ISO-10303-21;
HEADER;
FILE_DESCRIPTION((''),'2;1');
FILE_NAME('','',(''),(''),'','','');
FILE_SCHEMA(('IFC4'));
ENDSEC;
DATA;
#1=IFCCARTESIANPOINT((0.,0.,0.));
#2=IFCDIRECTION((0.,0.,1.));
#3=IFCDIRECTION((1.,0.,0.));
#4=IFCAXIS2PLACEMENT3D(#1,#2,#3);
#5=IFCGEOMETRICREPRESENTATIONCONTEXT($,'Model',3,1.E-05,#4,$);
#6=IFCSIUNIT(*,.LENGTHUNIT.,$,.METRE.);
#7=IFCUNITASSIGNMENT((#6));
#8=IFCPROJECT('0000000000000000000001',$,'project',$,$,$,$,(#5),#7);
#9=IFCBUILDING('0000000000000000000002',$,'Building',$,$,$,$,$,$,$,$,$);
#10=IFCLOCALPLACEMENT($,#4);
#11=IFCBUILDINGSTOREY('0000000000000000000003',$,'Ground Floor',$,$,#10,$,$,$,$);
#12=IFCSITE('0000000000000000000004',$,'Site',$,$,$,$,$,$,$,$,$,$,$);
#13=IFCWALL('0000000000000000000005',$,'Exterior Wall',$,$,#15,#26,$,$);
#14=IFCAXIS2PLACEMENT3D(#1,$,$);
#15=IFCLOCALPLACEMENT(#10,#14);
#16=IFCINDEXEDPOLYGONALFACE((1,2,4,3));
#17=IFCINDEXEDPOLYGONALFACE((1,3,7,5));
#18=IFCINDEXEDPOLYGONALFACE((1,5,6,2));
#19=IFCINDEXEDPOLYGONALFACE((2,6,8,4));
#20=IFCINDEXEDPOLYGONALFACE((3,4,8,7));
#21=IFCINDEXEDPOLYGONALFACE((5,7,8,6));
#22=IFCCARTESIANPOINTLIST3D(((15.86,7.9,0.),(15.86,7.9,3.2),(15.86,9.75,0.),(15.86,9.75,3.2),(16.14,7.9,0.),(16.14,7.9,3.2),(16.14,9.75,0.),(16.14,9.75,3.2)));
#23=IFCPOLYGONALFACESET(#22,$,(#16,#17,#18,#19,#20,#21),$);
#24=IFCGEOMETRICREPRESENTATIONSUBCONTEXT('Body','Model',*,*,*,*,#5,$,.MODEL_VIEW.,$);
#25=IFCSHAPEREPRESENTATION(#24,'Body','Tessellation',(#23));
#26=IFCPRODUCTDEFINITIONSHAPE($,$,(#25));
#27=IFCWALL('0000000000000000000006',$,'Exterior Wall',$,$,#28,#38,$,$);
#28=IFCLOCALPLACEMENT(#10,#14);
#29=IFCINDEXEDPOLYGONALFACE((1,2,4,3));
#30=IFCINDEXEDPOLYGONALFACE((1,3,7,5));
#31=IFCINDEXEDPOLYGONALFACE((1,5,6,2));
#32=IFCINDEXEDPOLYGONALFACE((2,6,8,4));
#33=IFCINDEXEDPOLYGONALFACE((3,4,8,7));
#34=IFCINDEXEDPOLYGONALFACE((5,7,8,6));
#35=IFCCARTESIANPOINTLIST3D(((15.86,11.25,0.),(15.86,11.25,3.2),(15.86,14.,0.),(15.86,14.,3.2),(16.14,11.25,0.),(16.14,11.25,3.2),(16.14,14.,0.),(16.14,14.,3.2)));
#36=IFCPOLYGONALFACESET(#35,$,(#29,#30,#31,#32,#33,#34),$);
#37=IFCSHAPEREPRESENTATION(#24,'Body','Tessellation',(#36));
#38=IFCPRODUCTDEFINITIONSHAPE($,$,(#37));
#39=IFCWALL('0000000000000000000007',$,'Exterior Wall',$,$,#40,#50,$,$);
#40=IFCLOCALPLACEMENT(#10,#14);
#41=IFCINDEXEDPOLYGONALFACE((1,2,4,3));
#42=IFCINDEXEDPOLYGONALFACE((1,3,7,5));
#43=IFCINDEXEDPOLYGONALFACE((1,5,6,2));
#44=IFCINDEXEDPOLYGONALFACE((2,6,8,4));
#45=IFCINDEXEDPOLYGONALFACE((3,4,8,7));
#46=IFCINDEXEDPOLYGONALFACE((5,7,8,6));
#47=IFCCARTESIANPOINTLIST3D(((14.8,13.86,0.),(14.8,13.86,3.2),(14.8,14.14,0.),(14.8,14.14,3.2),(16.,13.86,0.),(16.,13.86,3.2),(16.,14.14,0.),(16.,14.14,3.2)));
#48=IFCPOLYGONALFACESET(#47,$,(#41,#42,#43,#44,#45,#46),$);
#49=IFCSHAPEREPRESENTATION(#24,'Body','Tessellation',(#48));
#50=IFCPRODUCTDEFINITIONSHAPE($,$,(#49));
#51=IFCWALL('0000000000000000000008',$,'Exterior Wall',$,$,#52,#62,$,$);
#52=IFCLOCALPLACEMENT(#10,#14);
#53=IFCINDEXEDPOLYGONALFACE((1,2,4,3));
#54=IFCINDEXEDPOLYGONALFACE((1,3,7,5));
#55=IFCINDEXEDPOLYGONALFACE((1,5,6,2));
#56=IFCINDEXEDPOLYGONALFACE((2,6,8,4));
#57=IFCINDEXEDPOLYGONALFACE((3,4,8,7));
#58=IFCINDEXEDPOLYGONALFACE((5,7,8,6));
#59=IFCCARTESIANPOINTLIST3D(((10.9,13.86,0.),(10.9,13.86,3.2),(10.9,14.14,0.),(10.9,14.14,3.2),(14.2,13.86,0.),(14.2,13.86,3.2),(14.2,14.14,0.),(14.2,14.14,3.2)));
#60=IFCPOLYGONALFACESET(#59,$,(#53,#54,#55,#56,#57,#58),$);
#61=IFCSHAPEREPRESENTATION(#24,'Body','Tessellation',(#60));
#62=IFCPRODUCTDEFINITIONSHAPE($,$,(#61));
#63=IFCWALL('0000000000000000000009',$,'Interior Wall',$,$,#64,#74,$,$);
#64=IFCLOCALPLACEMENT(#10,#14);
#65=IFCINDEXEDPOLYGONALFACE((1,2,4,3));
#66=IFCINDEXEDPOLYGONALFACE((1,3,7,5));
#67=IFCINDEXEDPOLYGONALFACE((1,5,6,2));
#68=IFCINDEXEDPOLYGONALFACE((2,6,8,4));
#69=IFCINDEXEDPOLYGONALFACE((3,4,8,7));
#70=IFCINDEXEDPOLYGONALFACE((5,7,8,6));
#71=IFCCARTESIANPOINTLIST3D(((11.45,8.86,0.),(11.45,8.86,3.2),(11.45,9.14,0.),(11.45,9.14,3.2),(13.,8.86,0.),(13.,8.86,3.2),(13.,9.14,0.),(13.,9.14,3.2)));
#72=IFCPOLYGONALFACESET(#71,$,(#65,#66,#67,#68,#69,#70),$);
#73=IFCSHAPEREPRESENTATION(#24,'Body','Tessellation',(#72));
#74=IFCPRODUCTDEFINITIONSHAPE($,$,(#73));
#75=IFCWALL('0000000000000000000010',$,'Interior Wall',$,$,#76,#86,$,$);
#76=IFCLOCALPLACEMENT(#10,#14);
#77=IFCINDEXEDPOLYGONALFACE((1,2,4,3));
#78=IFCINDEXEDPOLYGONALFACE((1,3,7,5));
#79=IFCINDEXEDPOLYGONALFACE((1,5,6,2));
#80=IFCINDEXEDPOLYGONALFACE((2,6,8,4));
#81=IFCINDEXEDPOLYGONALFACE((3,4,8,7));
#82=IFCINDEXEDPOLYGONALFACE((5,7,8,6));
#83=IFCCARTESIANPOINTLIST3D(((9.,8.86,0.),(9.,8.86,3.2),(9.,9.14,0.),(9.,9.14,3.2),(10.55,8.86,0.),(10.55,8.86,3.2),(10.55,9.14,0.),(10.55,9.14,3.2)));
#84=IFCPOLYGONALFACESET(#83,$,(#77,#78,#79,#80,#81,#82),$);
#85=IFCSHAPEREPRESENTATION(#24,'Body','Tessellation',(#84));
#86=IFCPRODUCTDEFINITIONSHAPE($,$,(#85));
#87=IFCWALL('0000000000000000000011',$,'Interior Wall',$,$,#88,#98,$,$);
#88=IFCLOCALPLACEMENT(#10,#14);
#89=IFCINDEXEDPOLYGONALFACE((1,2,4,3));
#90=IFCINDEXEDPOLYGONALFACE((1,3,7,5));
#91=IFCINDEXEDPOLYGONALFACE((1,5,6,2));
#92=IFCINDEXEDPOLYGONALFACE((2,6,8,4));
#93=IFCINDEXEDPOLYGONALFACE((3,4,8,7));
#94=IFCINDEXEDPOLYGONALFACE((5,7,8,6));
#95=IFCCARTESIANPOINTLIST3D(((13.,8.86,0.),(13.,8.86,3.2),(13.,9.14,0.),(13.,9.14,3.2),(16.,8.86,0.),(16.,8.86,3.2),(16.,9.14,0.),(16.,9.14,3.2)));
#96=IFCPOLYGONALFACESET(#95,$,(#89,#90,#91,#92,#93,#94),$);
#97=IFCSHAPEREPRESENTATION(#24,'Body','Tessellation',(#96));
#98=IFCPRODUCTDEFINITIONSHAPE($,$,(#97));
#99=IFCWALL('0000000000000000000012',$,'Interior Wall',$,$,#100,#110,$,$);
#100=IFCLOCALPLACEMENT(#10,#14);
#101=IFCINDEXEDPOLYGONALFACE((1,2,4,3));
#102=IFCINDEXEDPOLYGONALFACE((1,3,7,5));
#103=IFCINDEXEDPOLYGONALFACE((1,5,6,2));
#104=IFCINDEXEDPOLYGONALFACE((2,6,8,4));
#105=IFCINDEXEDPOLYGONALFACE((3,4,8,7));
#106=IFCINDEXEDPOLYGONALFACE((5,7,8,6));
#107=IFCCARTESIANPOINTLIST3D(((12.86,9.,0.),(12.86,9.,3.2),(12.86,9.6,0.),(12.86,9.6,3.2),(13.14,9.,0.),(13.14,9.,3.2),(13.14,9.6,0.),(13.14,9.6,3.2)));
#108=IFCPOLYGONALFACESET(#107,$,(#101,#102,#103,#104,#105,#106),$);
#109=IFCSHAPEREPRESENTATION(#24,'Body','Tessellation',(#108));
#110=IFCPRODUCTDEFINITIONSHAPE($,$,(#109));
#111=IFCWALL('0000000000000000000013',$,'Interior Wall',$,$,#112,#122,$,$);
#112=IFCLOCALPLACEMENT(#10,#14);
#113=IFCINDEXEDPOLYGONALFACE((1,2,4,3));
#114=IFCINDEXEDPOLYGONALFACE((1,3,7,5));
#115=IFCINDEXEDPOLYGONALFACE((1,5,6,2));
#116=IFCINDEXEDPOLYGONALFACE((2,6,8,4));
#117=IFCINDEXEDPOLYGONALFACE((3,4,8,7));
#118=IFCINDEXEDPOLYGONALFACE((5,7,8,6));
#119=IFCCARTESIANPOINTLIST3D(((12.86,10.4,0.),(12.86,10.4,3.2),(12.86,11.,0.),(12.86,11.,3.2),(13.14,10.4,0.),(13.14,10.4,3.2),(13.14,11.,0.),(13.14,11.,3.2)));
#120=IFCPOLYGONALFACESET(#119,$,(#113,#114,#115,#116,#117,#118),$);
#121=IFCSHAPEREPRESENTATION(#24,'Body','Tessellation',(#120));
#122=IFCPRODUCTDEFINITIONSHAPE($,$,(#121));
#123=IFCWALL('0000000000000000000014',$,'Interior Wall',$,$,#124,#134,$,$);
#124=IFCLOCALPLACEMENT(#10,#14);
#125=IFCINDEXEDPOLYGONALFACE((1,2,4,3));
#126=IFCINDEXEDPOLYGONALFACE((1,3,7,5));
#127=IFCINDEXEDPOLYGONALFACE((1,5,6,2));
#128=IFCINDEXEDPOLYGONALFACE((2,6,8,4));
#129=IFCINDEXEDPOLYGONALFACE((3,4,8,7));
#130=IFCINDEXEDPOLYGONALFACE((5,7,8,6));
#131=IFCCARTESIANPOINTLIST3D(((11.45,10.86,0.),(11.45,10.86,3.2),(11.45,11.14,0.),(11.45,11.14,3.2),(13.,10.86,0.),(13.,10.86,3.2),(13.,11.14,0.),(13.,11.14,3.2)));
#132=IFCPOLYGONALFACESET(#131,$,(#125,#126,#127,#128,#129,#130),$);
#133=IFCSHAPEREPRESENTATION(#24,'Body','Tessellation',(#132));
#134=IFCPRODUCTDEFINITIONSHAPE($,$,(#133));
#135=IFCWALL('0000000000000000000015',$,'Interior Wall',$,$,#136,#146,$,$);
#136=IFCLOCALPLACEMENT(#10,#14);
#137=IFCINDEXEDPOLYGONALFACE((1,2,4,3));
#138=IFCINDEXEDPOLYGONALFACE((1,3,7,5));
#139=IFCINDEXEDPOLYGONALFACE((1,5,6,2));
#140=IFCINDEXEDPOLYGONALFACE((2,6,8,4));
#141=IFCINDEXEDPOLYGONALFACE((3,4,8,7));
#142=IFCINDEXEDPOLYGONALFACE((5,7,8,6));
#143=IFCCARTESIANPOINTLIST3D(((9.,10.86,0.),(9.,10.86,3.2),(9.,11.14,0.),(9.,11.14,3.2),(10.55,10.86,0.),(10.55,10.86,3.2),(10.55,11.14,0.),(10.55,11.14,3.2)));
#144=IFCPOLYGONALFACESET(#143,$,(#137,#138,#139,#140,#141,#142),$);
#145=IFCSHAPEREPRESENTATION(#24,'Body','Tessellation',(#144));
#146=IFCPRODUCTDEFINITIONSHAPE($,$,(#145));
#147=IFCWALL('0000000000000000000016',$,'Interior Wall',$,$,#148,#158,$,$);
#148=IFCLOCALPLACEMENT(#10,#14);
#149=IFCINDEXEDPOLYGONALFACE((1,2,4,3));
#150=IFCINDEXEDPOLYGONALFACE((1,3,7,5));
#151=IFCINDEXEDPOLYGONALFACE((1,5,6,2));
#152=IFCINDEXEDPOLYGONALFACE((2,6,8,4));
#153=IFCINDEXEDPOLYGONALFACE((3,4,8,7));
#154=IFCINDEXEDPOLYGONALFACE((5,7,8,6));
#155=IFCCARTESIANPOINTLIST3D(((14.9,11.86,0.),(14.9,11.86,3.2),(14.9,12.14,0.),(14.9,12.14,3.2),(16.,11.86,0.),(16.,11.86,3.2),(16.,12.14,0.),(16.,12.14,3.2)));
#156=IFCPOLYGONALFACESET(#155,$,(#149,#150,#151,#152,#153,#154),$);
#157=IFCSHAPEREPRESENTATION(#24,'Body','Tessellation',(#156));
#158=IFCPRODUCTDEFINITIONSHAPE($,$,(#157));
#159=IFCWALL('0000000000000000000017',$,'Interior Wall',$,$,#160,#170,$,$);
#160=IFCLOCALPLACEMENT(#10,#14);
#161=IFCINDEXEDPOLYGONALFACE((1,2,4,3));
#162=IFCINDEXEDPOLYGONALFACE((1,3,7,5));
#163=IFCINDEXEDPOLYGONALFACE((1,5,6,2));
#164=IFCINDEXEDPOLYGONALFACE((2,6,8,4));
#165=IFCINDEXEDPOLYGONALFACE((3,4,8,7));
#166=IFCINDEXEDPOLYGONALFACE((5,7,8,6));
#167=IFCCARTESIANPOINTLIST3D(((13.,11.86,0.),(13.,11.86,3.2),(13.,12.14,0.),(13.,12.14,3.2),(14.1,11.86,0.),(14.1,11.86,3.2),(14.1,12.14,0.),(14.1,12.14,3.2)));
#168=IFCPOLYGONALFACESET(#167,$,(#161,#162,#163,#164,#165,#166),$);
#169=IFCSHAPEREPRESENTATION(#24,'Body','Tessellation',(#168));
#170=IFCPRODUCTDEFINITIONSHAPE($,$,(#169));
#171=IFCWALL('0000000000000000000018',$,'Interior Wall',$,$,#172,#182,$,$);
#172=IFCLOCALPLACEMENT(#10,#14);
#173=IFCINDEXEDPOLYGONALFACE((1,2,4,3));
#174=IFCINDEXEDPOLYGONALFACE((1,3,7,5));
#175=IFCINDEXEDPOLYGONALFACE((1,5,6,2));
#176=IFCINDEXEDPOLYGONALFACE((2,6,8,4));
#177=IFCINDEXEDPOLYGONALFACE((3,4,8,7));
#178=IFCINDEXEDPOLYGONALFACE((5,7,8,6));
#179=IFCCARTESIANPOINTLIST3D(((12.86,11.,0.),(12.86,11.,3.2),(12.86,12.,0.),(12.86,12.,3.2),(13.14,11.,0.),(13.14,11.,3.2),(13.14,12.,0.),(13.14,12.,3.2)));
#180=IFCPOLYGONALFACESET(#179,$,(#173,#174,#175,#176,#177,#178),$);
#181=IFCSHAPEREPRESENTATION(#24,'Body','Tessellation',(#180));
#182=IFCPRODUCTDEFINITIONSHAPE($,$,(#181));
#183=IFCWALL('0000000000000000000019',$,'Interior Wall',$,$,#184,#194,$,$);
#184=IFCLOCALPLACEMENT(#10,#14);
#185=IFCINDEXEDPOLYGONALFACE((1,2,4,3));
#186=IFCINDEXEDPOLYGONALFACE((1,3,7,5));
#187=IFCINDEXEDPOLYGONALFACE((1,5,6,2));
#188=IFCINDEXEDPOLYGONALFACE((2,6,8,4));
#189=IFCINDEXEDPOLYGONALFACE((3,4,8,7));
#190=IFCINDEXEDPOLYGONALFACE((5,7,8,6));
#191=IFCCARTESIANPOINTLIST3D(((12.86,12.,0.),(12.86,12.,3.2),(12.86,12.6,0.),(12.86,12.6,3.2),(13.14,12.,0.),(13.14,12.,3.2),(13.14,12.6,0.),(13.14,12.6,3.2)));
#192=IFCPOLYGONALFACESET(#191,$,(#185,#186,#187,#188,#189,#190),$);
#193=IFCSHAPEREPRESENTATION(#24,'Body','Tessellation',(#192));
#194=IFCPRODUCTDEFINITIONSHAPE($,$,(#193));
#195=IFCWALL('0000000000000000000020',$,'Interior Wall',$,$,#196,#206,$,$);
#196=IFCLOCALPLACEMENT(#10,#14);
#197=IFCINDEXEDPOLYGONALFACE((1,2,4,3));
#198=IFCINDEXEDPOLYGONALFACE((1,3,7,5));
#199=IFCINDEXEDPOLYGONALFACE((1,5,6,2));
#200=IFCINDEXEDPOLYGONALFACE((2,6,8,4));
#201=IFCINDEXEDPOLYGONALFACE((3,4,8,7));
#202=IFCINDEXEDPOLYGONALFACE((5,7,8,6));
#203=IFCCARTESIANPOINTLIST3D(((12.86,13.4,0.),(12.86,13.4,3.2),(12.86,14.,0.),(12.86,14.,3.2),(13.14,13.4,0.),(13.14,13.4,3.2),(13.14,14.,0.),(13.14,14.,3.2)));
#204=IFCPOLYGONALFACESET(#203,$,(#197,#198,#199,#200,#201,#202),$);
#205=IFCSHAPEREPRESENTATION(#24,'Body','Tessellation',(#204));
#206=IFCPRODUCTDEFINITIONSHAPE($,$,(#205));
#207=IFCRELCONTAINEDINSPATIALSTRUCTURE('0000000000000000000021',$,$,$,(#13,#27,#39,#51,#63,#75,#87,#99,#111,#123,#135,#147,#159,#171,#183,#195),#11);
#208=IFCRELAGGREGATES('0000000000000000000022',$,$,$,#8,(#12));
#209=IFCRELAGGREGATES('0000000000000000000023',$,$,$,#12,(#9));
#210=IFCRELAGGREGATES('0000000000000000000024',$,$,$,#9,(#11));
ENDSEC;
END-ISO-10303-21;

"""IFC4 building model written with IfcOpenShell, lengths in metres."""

from ifc_helpers import new_model, si_unit, frame, origin_with_axes, place, context, subcontext, project, spatial, indexed_curve, outline, extrude, element, save


model = new_model("IFC4")

# Units and contexts
model_context = context("Model", 3, precision=1e-05, world=origin_with_axes())
body_context = subcontext(model_context, "Body", "Model", "MODEL_VIEW")
ifc_project = project(units=[si_unit("LENGTHUNIT", "METRE")], contexts=[model_context])

# Site, building, storey
site = spatial("IfcSite", under=ifc_project, Name="Site")
building = spatial("IfcBuilding", under=site, Name="Building")
storey_placement = place(None, origin_with_axes())
storey = spatial("IfcBuildingStorey", under=building, at=storey_placement, Name="Ground Floor")

# Walls
wall_1_placement = place(storey_placement, frame((16.0, 7.9, 0.0), z_axis=(0.0, 0.0, 1.0), x_axis=(0.0, 1.0, 0.0)))
element("IfcWall", 1, at=wall_1_placement, inside=storey, Name="Exterior Wall", context=body_context, shape_type="SweptSolid", body=[
    extrude(outline(indexed_curve([(0.0, 0.0), (0.0, 0.28), (1.85, 0.28), (1.85, 0.0), (0.0, 0.0)], self_intersect=False)), frame((0.0, -0.14, 0.0), z_axis=(0.0, 0.0, 1.0), x_axis=(1.0, 0.0, 0.0)), (0.0, 0.0, 1.0), 3.2),
])
wall_2_placement = place(storey_placement, frame((16.0, 11.25, 0.0), z_axis=(0.0, 0.0, 1.0), x_axis=(0.0, 1.0, 0.0)))
element("IfcWall", 2, at=wall_2_placement, inside=storey, Name="Exterior Wall", context=body_context, shape_type="SweptSolid", body=[
    extrude(outline(indexed_curve([(0.0, 0.0), (0.0, 0.28), (2.75, 0.28), (2.75, 0.0), (0.0, 0.0)], self_intersect=False)), frame((0.0, -0.14, 0.0), z_axis=(0.0, 0.0, 1.0), x_axis=(1.0, 0.0, 0.0)), (0.0, 0.0, 1.0), 3.2),
])
wall_3_placement = place(storey_placement, frame((16.0, 14.0, 0.0), z_axis=(0.0, 0.0, 1.0), x_axis=(-1.0, 0.0, 0.0)))
element("IfcWall", 3, at=wall_3_placement, inside=storey, Name="Exterior Wall", context=body_context, shape_type="SweptSolid", body=[
    extrude(outline(indexed_curve([(0.0, 0.0), (0.0, 0.28), (1.2, 0.28), (1.2, 0.0), (0.0, 0.0)], self_intersect=False)), frame((0.0, -0.14, 0.0), z_axis=(0.0, 0.0, 1.0), x_axis=(1.0, 0.0, 0.0)), (0.0, 0.0, 1.0), 3.2),
])
wall_4_placement = place(storey_placement, frame((14.2, 14.0, 0.0), z_axis=(0.0, 0.0, 1.0), x_axis=(-1.0, 0.0, 0.0)))
element("IfcWall", 4, at=wall_4_placement, inside=storey, Name="Exterior Wall", context=body_context, shape_type="SweptSolid", body=[
    extrude(outline(indexed_curve([(0.0, 0.0), (0.0, 0.28), (3.3, 0.28), (3.3, 0.0), (0.0, 0.0)], self_intersect=False)), frame((0.0, -0.14, 0.0), z_axis=(0.0, 0.0, 1.0), x_axis=(1.0, 0.0, 0.0)), (0.0, 0.0, 1.0), 3.2),
])
for number, where, z_axis, x_axis, name in (
    (5, (13.0, 9.0, 0.0), (0.0, 0.0, 1.0), (-1.0, 0.0, 0.0), "Interior Wall"),
    (6, (10.55, 9.0, 0.0), (0.0, 0.0, 1.0), (-1.0, 0.0, 0.0), "Interior Wall"),
):
    element("IfcWall", number, at=place(storey_placement, frame(where, z_axis=z_axis, x_axis=x_axis)), inside=storey, Name=name, context=body_context, shape_type="SweptSolid", body=[
        extrude(outline(indexed_curve([(0.0, 0.0), (0.0, 0.28), (1.55, 0.28), (1.55, 0.0), (0.0, 0.0)], self_intersect=False)), frame((0.0, -0.14, 0.0), z_axis=(0.0, 0.0, 1.0), x_axis=(1.0, 0.0, 0.0)), (0.0, 0.0, 1.0), 3.2),
    ])
wall_5_placement = place(storey_placement, frame((16.0, 9.0, 0.0), z_axis=(0.0, 0.0, 1.0), x_axis=(-1.0, 0.0, 0.0)))
element("IfcWall", 7, at=wall_5_placement, inside=storey, Name="Interior Wall", context=body_context, shape_type="SweptSolid", body=[
    extrude(outline(indexed_curve([(0.0, 0.0), (0.0, 0.28), (3.0, 0.28), (3.0, 0.0), (0.0, 0.0)], self_intersect=False)), frame((0.0, -0.14, 0.0), z_axis=(0.0, 0.0, 1.0), x_axis=(1.0, 0.0, 0.0)), (0.0, 0.0, 1.0), 3.2),
])
for number, where, z_axis, x_axis, name in (
    (8, (13.0, 9.0, 0.0), (0.0, 0.0, 1.0), (0.0, 1.0, 0.0), "Interior Wall"),
    (9, (13.0, 10.4, 0.0), (0.0, 0.0, 1.0), (0.0, 1.0, 0.0), "Interior Wall"),
):
    element("IfcWall", number, at=place(storey_placement, frame(where, z_axis=z_axis, x_axis=x_axis)), inside=storey, Name=name, context=body_context, shape_type="SweptSolid", body=[
        extrude(outline(indexed_curve([(0.0, 0.0), (0.0, 0.28), (0.6, 0.28), (0.6, 0.0), (0.0, 0.0)], self_intersect=False)), frame((0.0, -0.14, 0.0), z_axis=(0.0, 0.0, 1.0), x_axis=(1.0, 0.0, 0.0)), (0.0, 0.0, 1.0), 3.2),
    ])
for number, where, z_axis, x_axis, name in (
    (10, (13.0, 11.0, 0.0), (0.0, 0.0, 1.0), (-1.0, 0.0, 0.0), "Interior Wall"),
    (11, (10.55, 11.0, 0.0), (0.0, 0.0, 1.0), (-1.0, 0.0, 0.0), "Interior Wall"),
):
    element("IfcWall", number, at=place(storey_placement, frame(where, z_axis=z_axis, x_axis=x_axis)), inside=storey, Name=name, context=body_context, shape_type="SweptSolid", body=[
        extrude(outline(indexed_curve([(0.0, 0.0), (0.0, 0.28), (1.55, 0.28), (1.55, 0.0), (0.0, 0.0)], self_intersect=False)), frame((0.0, -0.14, 0.0), z_axis=(0.0, 0.0, 1.0), x_axis=(1.0, 0.0, 0.0)), (0.0, 0.0, 1.0), 3.2),
    ])
for number, where, z_axis, x_axis, name in (
    (12, (16.0, 12.0, 0.0), (0.0, 0.0, 1.0), (-1.0, 0.0, 0.0), "Interior Wall"),
    (13, (14.1, 12.0, 0.0), (0.0, 0.0, 1.0), (-1.0, 0.0, 0.0), "Interior Wall"),
):
    element("IfcWall", number, at=place(storey_placement, frame(where, z_axis=z_axis, x_axis=x_axis)), inside=storey, Name=name, context=body_context, shape_type="SweptSolid", body=[
        extrude(outline(indexed_curve([(0.0, 0.0), (0.0, 0.28), (1.1, 0.28), (1.1, 0.0), (0.0, 0.0)], self_intersect=False)), frame((0.0, -0.14, 0.0), z_axis=(0.0, 0.0, 1.0), x_axis=(1.0, 0.0, 0.0)), (0.0, 0.0, 1.0), 3.2),
    ])
wall_6_placement = place(storey_placement, frame((13.0, 12.0, 0.0), z_axis=(0.0, 0.0, 1.0), x_axis=(0.0, -1.0, 0.0)))
element("IfcWall", 14, at=wall_6_placement, inside=storey, Name="Interior Wall", context=body_context, shape_type="SweptSolid", body=[
    extrude(outline(indexed_curve([(0.0, 0.0), (0.0, 0.28), (1.0, 0.28), (1.0, 0.0), (0.0, 0.0)], self_intersect=False)), frame((0.0, -0.14, 0.0), z_axis=(0.0, 0.0, 1.0), x_axis=(1.0, 0.0, 0.0)), (0.0, 0.0, 1.0), 3.2),
])
for number, where, z_axis, x_axis, name in (
    (15, (13.0, 12.0, 0.0), (0.0, 0.0, 1.0), (0.0, 1.0, 0.0), "Interior Wall"),
    (16, (13.0, 13.4, 0.0), (0.0, 0.0, 1.0), (0.0, 1.0, 0.0), "Interior Wall"),
):
    element("IfcWall", number, at=place(storey_placement, frame(where, z_axis=z_axis, x_axis=x_axis)), inside=storey, Name=name, context=body_context, shape_type="SweptSolid", body=[
        extrude(outline(indexed_curve([(0.0, 0.0), (0.0, 0.28), (0.6, 0.28), (0.6, 0.0), (0.0, 0.0)], self_intersect=False)), frame((0.0, -0.14, 0.0), z_axis=(0.0, 0.0, 1.0), x_axis=(1.0, 0.0, 0.0)), (0.0, 0.0, 1.0), 3.2),
    ])

save(model, "model.ifc")
